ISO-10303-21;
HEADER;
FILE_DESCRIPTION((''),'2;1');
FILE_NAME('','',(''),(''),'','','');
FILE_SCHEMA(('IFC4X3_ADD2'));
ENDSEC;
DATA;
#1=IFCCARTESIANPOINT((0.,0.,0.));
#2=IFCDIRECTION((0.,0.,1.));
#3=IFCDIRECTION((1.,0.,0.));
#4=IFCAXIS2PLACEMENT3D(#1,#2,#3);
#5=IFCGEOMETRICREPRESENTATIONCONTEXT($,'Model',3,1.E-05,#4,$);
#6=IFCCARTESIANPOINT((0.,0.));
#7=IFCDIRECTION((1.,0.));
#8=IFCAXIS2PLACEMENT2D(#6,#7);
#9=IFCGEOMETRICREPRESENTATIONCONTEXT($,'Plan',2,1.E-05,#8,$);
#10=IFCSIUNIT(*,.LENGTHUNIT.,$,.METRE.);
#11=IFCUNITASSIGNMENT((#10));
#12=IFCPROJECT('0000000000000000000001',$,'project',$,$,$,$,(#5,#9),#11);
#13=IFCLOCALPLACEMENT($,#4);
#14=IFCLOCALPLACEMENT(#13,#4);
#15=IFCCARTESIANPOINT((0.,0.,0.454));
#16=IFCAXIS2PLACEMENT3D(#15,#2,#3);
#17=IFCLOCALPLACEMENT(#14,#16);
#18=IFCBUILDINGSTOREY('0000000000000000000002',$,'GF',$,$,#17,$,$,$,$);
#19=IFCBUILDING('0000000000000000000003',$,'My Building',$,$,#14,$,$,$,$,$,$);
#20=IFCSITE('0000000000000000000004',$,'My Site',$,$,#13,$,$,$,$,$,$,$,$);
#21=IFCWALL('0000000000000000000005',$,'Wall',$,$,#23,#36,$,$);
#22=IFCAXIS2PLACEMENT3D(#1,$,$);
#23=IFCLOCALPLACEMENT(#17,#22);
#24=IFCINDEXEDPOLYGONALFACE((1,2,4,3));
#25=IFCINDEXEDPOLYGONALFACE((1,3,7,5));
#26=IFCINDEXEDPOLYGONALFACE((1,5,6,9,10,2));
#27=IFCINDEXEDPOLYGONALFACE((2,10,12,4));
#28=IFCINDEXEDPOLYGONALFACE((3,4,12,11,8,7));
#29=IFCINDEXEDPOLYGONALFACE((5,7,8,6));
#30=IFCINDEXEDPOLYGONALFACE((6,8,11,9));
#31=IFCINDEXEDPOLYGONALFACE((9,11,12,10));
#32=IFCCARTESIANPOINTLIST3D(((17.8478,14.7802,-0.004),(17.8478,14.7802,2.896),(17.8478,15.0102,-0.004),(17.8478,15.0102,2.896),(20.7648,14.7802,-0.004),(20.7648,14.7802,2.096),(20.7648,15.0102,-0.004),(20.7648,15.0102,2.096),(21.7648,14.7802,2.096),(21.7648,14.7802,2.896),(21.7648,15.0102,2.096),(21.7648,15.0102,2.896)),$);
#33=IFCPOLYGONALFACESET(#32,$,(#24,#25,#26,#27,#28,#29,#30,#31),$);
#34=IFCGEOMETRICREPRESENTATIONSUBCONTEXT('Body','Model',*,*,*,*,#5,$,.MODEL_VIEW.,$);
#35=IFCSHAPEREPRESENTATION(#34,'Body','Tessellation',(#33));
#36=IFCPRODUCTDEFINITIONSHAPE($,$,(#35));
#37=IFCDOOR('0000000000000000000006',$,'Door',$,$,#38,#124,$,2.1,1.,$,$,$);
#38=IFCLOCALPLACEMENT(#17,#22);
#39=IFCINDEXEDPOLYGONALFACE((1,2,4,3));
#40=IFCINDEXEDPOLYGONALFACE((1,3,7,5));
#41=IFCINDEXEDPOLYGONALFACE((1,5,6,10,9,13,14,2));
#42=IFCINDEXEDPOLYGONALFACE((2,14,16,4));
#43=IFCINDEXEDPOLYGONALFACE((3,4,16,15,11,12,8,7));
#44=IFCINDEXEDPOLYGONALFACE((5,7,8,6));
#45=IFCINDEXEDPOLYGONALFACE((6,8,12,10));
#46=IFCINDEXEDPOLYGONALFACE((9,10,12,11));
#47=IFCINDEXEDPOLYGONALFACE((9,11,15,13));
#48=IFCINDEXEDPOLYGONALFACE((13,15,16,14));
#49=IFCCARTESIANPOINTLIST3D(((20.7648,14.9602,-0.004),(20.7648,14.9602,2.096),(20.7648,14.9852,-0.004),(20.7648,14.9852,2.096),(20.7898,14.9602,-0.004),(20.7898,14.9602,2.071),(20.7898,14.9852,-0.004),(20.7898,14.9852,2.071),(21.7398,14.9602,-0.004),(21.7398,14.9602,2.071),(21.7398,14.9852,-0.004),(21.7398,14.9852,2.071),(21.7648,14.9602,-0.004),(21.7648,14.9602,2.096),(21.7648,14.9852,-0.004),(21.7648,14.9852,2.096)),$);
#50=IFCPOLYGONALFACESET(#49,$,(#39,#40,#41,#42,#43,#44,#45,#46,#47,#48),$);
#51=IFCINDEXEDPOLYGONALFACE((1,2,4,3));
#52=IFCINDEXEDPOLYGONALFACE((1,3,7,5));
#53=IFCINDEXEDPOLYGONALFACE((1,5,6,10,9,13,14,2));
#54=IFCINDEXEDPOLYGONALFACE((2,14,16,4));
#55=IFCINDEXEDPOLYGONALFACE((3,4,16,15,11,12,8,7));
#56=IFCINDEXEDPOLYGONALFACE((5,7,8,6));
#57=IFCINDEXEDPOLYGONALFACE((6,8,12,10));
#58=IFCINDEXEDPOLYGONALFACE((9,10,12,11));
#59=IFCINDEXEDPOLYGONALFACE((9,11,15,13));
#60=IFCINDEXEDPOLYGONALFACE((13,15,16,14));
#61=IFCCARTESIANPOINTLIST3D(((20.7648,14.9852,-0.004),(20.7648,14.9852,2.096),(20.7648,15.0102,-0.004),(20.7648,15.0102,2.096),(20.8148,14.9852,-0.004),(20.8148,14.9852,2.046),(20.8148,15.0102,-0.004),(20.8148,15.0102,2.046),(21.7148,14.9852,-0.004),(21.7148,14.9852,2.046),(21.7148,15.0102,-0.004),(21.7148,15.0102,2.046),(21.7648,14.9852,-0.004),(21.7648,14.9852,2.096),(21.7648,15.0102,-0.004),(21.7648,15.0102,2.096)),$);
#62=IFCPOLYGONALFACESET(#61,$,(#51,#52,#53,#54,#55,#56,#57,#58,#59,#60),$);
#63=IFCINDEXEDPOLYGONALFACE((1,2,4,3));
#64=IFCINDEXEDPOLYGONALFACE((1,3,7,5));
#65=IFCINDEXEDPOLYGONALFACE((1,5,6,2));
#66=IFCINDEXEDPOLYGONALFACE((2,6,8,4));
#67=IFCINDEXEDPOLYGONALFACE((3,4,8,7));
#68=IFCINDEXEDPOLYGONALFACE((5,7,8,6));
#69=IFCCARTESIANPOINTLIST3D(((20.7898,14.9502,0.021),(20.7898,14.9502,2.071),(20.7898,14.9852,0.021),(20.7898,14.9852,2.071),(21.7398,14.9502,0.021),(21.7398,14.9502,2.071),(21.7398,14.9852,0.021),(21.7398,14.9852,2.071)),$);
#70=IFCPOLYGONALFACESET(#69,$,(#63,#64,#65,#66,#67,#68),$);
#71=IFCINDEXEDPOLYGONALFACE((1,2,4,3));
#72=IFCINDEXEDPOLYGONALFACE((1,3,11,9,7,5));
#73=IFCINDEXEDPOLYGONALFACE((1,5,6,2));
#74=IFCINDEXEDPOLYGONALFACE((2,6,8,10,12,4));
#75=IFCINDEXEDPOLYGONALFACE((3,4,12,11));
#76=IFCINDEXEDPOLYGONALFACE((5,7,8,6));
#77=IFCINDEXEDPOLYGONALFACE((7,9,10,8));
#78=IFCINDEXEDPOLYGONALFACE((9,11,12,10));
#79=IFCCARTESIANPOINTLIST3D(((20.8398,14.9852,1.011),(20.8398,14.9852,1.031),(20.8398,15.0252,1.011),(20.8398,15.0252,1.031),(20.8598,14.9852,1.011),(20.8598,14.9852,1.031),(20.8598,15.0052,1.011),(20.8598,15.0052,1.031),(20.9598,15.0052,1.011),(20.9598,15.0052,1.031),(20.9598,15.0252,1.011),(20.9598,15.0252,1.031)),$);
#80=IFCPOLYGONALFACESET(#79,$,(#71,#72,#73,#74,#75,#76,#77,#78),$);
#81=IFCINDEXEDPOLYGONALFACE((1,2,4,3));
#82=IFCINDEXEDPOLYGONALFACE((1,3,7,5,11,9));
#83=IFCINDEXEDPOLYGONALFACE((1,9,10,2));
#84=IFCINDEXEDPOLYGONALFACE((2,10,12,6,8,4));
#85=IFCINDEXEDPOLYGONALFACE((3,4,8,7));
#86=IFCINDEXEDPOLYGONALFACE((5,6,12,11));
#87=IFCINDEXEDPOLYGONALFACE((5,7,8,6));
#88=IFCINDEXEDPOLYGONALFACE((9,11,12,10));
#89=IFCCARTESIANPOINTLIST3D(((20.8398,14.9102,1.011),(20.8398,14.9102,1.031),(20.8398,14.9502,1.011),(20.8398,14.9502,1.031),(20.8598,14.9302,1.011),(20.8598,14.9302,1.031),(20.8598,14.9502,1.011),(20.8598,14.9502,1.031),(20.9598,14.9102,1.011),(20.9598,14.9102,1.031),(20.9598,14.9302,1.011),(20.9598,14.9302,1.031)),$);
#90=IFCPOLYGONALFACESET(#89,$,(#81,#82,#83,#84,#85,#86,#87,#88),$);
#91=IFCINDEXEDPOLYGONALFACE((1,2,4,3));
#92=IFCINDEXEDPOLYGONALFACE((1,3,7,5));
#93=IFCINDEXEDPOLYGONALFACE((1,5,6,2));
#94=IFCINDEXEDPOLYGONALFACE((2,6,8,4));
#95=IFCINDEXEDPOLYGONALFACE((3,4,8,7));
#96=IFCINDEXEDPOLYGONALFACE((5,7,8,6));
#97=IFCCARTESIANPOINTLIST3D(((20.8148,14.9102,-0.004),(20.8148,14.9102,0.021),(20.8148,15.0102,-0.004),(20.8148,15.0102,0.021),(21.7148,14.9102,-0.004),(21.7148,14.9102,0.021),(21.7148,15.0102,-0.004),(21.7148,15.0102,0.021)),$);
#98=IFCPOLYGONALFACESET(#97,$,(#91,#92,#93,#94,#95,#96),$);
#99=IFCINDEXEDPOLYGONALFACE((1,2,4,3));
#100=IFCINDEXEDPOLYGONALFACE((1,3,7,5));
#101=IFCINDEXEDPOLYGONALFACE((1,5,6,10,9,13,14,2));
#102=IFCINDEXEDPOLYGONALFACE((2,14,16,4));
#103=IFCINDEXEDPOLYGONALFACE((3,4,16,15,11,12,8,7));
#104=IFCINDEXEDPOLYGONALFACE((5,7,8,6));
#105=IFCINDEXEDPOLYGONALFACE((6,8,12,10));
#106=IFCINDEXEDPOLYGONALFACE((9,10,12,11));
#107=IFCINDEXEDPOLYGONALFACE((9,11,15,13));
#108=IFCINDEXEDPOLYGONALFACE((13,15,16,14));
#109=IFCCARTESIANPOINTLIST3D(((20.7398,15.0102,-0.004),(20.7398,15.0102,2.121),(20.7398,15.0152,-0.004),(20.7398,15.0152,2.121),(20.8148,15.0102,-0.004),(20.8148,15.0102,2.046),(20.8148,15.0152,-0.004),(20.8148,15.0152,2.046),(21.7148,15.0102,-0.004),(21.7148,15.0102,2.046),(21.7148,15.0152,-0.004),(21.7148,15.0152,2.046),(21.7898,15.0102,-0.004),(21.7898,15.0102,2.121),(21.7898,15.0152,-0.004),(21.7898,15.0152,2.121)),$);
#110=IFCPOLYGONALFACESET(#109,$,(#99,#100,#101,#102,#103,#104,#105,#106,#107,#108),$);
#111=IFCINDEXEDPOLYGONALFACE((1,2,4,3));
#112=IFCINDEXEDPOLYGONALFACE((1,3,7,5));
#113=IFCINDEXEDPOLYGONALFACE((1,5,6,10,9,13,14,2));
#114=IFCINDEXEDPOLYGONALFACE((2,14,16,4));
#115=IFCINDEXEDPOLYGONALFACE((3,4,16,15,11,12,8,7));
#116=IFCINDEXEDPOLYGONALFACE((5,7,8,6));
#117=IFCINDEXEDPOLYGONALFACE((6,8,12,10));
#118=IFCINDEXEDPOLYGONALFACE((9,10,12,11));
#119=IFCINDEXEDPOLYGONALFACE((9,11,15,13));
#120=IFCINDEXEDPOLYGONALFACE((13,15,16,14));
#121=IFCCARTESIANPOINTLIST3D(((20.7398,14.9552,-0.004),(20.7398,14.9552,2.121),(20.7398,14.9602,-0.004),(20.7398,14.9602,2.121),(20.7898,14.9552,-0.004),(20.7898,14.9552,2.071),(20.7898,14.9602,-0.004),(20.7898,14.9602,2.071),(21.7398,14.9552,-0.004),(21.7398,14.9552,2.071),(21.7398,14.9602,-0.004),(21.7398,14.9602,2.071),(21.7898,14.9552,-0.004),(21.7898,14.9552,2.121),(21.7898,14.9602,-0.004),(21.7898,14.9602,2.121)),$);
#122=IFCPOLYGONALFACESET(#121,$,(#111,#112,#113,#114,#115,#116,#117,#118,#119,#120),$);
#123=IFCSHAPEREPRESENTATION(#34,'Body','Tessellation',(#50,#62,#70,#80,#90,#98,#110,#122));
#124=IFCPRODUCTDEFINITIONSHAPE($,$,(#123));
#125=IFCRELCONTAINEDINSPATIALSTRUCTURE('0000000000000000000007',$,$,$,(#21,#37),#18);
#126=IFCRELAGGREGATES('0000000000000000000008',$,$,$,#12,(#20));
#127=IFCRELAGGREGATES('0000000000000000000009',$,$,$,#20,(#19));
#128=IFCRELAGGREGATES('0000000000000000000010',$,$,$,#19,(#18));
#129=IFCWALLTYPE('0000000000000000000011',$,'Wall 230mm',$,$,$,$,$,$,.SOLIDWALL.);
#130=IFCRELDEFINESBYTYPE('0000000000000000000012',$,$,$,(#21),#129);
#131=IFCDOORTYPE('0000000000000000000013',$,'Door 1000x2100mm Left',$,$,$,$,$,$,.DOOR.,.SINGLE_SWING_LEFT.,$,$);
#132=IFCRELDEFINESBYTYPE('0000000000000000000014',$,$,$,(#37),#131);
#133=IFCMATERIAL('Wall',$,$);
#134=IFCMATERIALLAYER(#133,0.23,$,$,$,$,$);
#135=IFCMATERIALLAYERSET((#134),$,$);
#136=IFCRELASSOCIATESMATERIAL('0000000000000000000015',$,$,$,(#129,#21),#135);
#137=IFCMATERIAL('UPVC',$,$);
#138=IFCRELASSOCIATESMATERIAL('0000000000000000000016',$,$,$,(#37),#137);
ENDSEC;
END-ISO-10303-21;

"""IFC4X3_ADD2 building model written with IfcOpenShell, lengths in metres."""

from ifc_helpers import new_model, entity, si_unit, frame, origin_with_axes, origin_2d_with_axis, place, context, subcontext, project, spatial, line, indexed_curve, outline, extrude, shape, source, transform, mapped, material, layer, layer_set, layer_usage, type_object, type_shapes, element, fill, save


model = new_model("IFC4X3_ADD2")

# Units and contexts
model_context = context("Model", 3, precision=1e-05, world=origin_with_axes())
plan_context = context("Plan", 2, precision=1e-05, world=origin_2d_with_axis())
body_context_1 = subcontext(model_context, "Body", "Model", "MODEL_VIEW")
body_context_2 = subcontext(plan_context, "Body", "Plan", "PLAN_VIEW")
ifc_project = project(units=[si_unit("LENGTHUNIT", "METRE")], contexts=[model_context, plan_context])

# Site, building, storey
site_placement = place(None, origin_with_axes())
site = spatial("IfcSite", under=ifc_project, at=site_placement, Name="My Site")
building_placement = place(site_placement, origin_with_axes())
building = spatial("IfcBuilding", under=site, at=building_placement, Name="My Building")
storey_placement = place(building_placement, frame((0.0, 0.0, 0.454), z_axis=(0.0, 0.0, 1.0), x_axis=(1.0, 0.0, 0.0)))
storey = spatial("IfcBuildingStorey", under=building, at=storey_placement, Name="GF")

# Shared definitions
ifc_material_1 = material(Name="UPVC")

# Shared definitions
ifc_material_2 = material(Name="Wall")
ifc_layer_1 = layer(ifc_material_2, 0.23)
ifc_layer_set_1 = layer_set([ifc_layer_1])
wall_type = type_object("IfcWallType", Name="Wall 230mm", PredefinedType="SOLIDWALL", material=ifc_layer_set_1)

# Wall, opening, door
ifc_layer_usage_1 = layer_usage(ifc_layer_set_1, "AXIS2", "POSITIVE", 0.0)
wall_1_placement = place(storey_placement, frame((21.7648, 15.0102, -0.004), z_axis=(0.0, 0.0, 1.0), x_axis=(-1.0, 0.0, 0.0)))
wall_1 = element("IfcWall", 1, at=wall_1_placement, inside=storey, type_object=wall_type, material=ifc_layer_usage_1, Name="Wall", context=body_context_1, shape_type="SweptSolid", body=[
    extrude(outline(indexed_curve([(0.0, 0.0), (0.0, 0.23), (3.917, 0.23), (3.917, 0.0), (0.0, 0.0)], self_intersect=False)), origin_with_axes(), (0.0, 0.0, 1.0), 2.9),
])
shared_shape_1 = source(origin_with_axes(), body_context_1, "Body", "SweptSolid", [
    extrude(outline(indexed_curve([(0.0, 0.0), (1.0, 0.0), (1.0, 2.1), (0.0, 2.1)], segments=[line(1, 2, 3, 4, 1)])), frame((0.0, -0.6, 0.0), z_axis=(0.0, -1.0, 0.0), x_axis=(1.0, 0.0, 0.0)), (0.0, 0.0, -1.0), 1.2),
])
opening_1_placement = place(wall_1_placement, frame((0.0, 0.0, 0.0), z_axis=(0.0, 0.0, 1.0), x_axis=(1.0, 0.0, 0.0)))
opening_1 = element("IfcOpeningElement", 2, at=opening_1_placement, cuts=wall_1, PredefinedType="OPENING", context=body_context_1, shape_type="MappedRepresentation", body=[
    mapped(shared_shape_1, transform((0.0, 0.0, 0.0), x_axis=(1.0, 0.0, 0.0), y_axis=(0.0, 1.0, 0.0), z_axis=(0.0, 0.0, 1.0), scale=1.0)),
])
door_type_1 = type_object("IfcDoorType", Name="Door 1000x2100mm Left", OperationType="SINGLE_SWING_LEFT", PredefinedType="DOOR")
shared_shape_2 = source(origin_with_axes(), body_context_1, "Body", "SweptSolid", [
    extrude(outline(indexed_curve([(0.0, 0.0), (0.0, 2.1), (1.0, 2.1), (1.0, 0.0), (0.975, 0.0), (0.975, 2.075), (0.025, 2.075), (0.025, 0.0)], segments=[line(1, 2, 3, 4, 5, 6, 7, 8, 1)])), frame((0.0, 0.025, 0.0), z_axis=(0.0, -1.0, 0.0), x_axis=(1.0, 0.0, 0.0)), (0.0, 0.0, -1.0), 0.025),
    extrude(outline(indexed_curve([(0.0, 0.0), (0.0, 2.1), (1.0, 2.1), (1.0, 0.0), (0.95, 0.0), (0.95, 2.05), (0.05, 2.05), (0.05, 0.0)], segments=[line(1, 2, 3, 4, 5, 6, 7, 8, 1)])), frame((0.0, 0.0, 0.0), z_axis=(0.0, -1.0, 0.0), x_axis=(1.0, 0.0, 0.0)), (0.0, 0.0, -1.0), 0.025),
    extrude(outline(indexed_curve([(0.0, 0.0), (0.95, 0.0), (0.95, 0.035), (0.0, 0.035)], segments=[line(1, 2, 3, 4, 1)])), frame((0.025, 0.025, 0.025), z_axis=(0.0, 0.0, 1.0), x_axis=(1.0, 0.0, 0.0)), (0.0, 0.0, 1.0), 2.05),
    extrude(outline(indexed_curve([(0.0, 0.0), (0.0, -0.04), (-0.12, -0.04), (-0.12, -0.02), (-0.02, -0.02), (-0.02, 0.0)], segments=[line(1, 2, 3, 4, 5, 6, 1)])), frame((0.925, 0.025, 1.015), z_axis=(0.0, 0.0, 1.0), x_axis=(1.0, 0.0, 0.0)), (0.0, 0.0, 1.0), 0.02),
    extrude(outline(indexed_curve([(0.0, 0.0), (0.0, 0.04), (-0.12, 0.04), (-0.12, 0.02), (-0.02, 0.02), (-0.02, 0.0)], segments=[line(1, 2, 3, 4, 5, 6, 1)])), frame((0.925, 0.06, 1.015), z_axis=(0.0, 0.0, 1.0), x_axis=(1.0, 0.0, 0.0)), (0.0, 0.0, 1.0), 0.02),
    extrude(outline(indexed_curve([(0.0, 0.0), (0.9, 0.0), (0.9, 0.1), (0.0, 0.1)], segments=[line(1, 2, 3, 4, 1)])), frame((0.05, 0.0, 0.0), z_axis=(0.0, 0.0, 1.0), x_axis=(1.0, 0.0, 0.0)), (0.0, 0.0, 1.0), 0.025),
    extrude(outline(indexed_curve([(0.0, 0.0), (0.0, 2.125), (1.05, 2.125), (1.05, 0.0), (0.975, 0.0), (0.975, 2.05), (0.075, 2.05), (0.075, 0.0)], segments=[line(1, 2, 3, 4, 5, 6, 7, 8, 1)])), frame((-0.025, -0.005, 0.0), z_axis=(0.0, -1.0, 0.0), x_axis=(1.0, 0.0, 0.0)), (0.0, 0.0, -1.0), 0.005),
    extrude(outline(indexed_curve([(0.0, 0.0), (0.0, 2.125), (1.05, 2.125), (1.05, 0.0), (1.0, 0.0), (1.0, 2.075), (0.05, 2.075), (0.05, 0.0)], segments=[line(1, 2, 3, 4, 5, 6, 7, 8, 1)])), frame((-0.025, 0.05, 0.0), z_axis=(0.0, -1.0, 0.0), x_axis=(1.0, 0.0, 0.0)), (0.0, 0.0, -1.0), 0.005),
])
shared_shape_3 = source(origin_with_axes(), body_context_2, "Body", "Curve2D", [
    entity("IfcIndexedPolyCurve", entity("IfcCartesianPointList2D", [[0.0, 0.0], [0.0, 0.05], [0.025, 0.05], [0.025, 0.025], [0.05, 0.025], [0.05, 0.0]]), [entity("IfcLineIndex", [1, 2, 3, 4, 5, 6, 1])]),
    entity("IfcIndexedPolyCurve", entity("IfcCartesianPointList2D", [[1.0, 0.0], [1.0, 0.05], [0.975, 0.05], [0.975, 0.025], [0.95, 0.025], [0.95, 0.0]]), [entity("IfcLineIndex", [1, 2, 3, 4, 5, 6, 1])]),
    entity("IfcTrimmedCurve", entity("IfcEllipse", entity("IfcAxis2Placement2D", entity("IfcCartesianPoint", [0.06, 0.05]), entity("IfcDirection", [1.0, 0.0])), 0.915, 0.95), [entity("IfcCartesianPoint", [0.975, 0.05])], [entity("IfcCartesianPoint", [0.06, 1.0])], True, "CARTESIAN"),
    entity("IfcIndexedPolyCurve", entity("IfcCartesianPointList2D", [[0.025, 0.05], [0.06, 0.05], [0.06, 1.0], [0.025, 1.0]]), [entity("IfcLineIndex", [1, 2, 3, 4, 1])]),
])
type_shapes(door_type_1, [shared_shape_2, shared_shape_3])
door_1_placement = place(opening_1_placement, frame((0.0, 0.0, 0.0), z_axis=(0.0, 0.0, 1.0), x_axis=(1.0, 0.0, 0.0)))
door_1 = element("IfcDoor", 3, at=door_1_placement, inside=storey, type_object=door_type_1, material=ifc_material_1, Name="Door", OverallHeight=2.1, OverallWidth=1.0, shapes=[
    shape(body_context_1, "Body", "MappedRepresentation", [mapped(shared_shape_2, transform((0.0, 0.0, 0.0), x_axis=(1.0, 0.0, 0.0), y_axis=(0.0, 1.0, 0.0), z_axis=(0.0, 0.0, 1.0), scale=1.0))]),
    shape(body_context_2, "Body", "MappedRepresentation", [mapped(shared_shape_3, transform((0.0, 0.0, 0.0), x_axis=(1.0, 0.0, 0.0), y_axis=(0.0, 1.0, 0.0), z_axis=(0.0, 0.0, 1.0), scale=1.0))]),
])
fill(opening_1, door_1)

save(model, "model.ifc")
